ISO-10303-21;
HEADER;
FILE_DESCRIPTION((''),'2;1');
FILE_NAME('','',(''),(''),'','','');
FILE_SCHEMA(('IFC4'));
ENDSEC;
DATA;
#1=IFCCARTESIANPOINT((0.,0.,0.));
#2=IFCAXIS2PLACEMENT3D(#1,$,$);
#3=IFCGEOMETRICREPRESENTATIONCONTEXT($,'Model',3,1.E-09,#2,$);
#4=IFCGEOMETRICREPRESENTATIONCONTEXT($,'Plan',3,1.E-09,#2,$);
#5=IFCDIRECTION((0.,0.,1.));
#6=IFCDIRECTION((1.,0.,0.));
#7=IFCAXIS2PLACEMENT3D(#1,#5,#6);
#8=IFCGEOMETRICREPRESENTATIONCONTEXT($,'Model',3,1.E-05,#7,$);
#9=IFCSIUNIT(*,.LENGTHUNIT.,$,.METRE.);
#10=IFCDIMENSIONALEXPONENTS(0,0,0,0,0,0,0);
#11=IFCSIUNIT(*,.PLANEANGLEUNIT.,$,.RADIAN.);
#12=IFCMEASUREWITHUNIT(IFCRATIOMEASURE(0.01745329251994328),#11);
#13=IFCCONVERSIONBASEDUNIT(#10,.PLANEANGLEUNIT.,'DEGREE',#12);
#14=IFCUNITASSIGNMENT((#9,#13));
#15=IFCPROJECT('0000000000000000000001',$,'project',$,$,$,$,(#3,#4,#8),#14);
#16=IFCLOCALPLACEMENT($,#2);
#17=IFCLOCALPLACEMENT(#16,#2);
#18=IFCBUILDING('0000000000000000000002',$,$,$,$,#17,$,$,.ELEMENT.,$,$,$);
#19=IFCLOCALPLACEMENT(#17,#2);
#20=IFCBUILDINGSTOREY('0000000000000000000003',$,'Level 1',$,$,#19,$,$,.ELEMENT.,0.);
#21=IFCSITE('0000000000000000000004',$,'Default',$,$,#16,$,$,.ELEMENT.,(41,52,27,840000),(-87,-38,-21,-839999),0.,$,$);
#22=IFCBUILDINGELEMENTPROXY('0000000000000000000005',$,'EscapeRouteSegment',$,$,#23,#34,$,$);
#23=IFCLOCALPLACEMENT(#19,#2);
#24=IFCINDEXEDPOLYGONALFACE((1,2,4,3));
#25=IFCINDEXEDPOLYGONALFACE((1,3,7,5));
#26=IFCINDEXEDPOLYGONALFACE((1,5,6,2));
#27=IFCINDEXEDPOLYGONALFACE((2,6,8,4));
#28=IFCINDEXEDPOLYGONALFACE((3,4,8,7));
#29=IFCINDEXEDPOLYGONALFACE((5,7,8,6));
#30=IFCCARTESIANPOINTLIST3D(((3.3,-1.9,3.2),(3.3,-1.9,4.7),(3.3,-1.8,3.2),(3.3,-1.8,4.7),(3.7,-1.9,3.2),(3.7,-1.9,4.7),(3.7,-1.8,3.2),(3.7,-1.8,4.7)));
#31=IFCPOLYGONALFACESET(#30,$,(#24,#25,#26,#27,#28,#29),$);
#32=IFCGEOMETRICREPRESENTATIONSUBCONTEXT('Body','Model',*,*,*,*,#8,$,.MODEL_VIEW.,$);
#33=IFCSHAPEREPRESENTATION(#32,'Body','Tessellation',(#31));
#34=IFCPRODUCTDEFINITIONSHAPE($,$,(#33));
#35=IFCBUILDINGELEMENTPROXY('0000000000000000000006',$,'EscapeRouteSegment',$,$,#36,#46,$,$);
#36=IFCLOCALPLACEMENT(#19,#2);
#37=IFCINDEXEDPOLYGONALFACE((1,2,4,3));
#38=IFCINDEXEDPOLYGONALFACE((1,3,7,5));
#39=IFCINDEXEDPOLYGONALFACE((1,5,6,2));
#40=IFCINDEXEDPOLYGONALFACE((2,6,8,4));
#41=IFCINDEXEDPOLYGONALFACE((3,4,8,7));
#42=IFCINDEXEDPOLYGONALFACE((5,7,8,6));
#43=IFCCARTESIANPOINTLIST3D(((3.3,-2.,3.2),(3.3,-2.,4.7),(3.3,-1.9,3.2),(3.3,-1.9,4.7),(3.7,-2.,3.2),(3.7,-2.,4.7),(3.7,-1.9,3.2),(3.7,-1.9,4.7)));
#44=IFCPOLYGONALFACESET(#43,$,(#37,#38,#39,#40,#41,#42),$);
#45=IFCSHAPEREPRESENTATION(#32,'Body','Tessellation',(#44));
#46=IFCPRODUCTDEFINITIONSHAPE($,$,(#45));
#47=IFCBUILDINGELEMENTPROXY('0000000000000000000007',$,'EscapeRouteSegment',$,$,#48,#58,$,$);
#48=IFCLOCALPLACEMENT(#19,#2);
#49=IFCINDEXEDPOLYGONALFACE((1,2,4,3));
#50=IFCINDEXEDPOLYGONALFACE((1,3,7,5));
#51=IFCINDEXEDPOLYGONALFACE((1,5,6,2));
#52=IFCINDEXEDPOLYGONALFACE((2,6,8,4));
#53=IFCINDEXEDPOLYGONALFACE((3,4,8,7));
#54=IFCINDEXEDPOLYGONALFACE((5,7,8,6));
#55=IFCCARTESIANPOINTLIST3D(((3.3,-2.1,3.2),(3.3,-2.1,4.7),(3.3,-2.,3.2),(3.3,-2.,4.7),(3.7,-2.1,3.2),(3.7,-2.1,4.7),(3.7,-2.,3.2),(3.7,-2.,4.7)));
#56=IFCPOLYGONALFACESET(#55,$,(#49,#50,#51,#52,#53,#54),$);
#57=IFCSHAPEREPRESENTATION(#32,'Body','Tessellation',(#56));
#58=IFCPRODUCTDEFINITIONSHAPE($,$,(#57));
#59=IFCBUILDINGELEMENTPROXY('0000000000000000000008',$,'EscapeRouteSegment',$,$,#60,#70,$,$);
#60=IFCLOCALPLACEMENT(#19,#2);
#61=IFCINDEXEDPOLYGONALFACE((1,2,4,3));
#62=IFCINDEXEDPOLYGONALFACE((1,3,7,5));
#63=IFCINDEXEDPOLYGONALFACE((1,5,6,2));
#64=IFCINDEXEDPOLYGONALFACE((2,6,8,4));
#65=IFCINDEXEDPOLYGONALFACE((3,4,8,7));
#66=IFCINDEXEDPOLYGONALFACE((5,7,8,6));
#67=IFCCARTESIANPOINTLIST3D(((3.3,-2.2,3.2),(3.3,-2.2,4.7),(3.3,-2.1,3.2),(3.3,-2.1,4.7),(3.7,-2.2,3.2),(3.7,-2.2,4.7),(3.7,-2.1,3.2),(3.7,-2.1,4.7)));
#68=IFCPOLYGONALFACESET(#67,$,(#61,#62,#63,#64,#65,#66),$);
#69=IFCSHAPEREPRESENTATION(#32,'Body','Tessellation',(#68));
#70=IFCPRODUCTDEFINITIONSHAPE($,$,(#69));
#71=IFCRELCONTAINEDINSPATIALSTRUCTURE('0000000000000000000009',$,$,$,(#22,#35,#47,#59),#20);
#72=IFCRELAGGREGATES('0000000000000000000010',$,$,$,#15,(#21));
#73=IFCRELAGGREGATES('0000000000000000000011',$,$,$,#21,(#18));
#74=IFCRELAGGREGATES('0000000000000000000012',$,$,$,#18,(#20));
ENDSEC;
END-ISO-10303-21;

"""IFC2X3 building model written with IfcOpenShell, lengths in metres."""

from ifc_helpers import new_model, entity, si_unit, converted_unit, frame, origin, origin_with_axes, place, context, subcontext, project, spatial, polyline, outline, extrude, element, save


model = new_model("IFC2X3")

# Units and contexts
model_context_1 = context("Model", 3, precision=1e-09, world=origin())
plan_context = context("Plan", 3, precision=1e-09, world=origin())
model_context_2 = context("Model", 3, precision=1e-05, world=origin_with_axes())
body_context = subcontext(model_context_2, "Body", "Model", "MODEL_VIEW")
ifc_project = project(units=[si_unit("LENGTHUNIT", "METRE"), converted_unit("PLANEANGLEUNIT", "DEGREE", entity("IfcRatioMeasure", 0.01745329251994328), si_unit("PLANEANGLEUNIT", "RADIAN"), dimensions=[0, 0, 0, 0, 0, 0, 0])], contexts=[model_context_1, plan_context, model_context_2])

# Site, building, storey
site_placement = place(None, origin())
site = spatial("IfcSite", under=ifc_project, at=site_placement, Name="Default", CompositionType="ELEMENT", RefLatitude=(41, 52, 27, 840000), RefLongitude=(-87, -38, -21, -839999), RefElevation=0.0)
building_placement = place(site_placement, origin())
building = spatial("IfcBuilding", under=site, at=building_placement, CompositionType="ELEMENT")
storey_placement = place(building_placement, origin())
storey = spatial("IfcBuildingStorey", under=building, at=storey_placement, Name="Level 1", CompositionType="ELEMENT", Elevation=0.0)

# Building element proxies
for number, where, z_axis, x_axis, name in (
    (1, (3.5, -1.8, 3.2), (0.0, 0.0, 1.0), (0.0, -1.0, 0.0), "EscapeRouteSegment"),
    (2, (3.5, -1.9, 3.2), (0.0, 0.0, 1.0), (0.0, -1.0, 0.0), "EscapeRouteSegment"),
):
    element("IfcBuildingElementProxy", number, at=place(storey_placement, frame(where, z_axis=z_axis, x_axis=x_axis)), inside=storey, Name=name, context=body_context, shape_type="SweptSolid", body=[
        extrude(outline(polyline([(0.0, -0.2), (0.0, 0.2), (0.1, 0.2), (0.1, -0.2), (0.0, -0.2)])), origin_with_axes(), (0.0, 0.0, 1.0), 1.5),
    ])
proxy_1_placement = place(storey_placement, frame((3.5, -2.0, 3.2), z_axis=(0.0, 0.0, 1.0), x_axis=(0.0, -1.0, 0.0)))
element("IfcBuildingElementProxy", 3, at=proxy_1_placement, inside=storey, Name="EscapeRouteSegment", context=body_context, shape_type="SweptSolid", body=[
    extrude(outline(polyline([(0.0, -0.2), (0.0, 0.2), (0.1, 0.2), (0.1, -0.2), (0.0, -0.2)])), origin_with_axes(), (0.0, 0.0, 1.0), 1.5),
])
proxy_2_placement = place(storey_placement, frame((3.5, -2.1, 3.2), z_axis=(0.0, 0.0, 1.0), x_axis=(0.0, -1.0, 0.0)))
element("IfcBuildingElementProxy", 4, at=proxy_2_placement, inside=storey, Name="EscapeRouteSegment", context=body_context, shape_type="SweptSolid", body=[
    extrude(outline(polyline([(0.0, -0.2), (0.0, 0.2), (0.1, 0.2), (0.1, -0.2), (0.0, -0.2)])), origin_with_axes(), (0.0, 0.0, 1.0), 1.5),
])

save(model, "model.ifc")
